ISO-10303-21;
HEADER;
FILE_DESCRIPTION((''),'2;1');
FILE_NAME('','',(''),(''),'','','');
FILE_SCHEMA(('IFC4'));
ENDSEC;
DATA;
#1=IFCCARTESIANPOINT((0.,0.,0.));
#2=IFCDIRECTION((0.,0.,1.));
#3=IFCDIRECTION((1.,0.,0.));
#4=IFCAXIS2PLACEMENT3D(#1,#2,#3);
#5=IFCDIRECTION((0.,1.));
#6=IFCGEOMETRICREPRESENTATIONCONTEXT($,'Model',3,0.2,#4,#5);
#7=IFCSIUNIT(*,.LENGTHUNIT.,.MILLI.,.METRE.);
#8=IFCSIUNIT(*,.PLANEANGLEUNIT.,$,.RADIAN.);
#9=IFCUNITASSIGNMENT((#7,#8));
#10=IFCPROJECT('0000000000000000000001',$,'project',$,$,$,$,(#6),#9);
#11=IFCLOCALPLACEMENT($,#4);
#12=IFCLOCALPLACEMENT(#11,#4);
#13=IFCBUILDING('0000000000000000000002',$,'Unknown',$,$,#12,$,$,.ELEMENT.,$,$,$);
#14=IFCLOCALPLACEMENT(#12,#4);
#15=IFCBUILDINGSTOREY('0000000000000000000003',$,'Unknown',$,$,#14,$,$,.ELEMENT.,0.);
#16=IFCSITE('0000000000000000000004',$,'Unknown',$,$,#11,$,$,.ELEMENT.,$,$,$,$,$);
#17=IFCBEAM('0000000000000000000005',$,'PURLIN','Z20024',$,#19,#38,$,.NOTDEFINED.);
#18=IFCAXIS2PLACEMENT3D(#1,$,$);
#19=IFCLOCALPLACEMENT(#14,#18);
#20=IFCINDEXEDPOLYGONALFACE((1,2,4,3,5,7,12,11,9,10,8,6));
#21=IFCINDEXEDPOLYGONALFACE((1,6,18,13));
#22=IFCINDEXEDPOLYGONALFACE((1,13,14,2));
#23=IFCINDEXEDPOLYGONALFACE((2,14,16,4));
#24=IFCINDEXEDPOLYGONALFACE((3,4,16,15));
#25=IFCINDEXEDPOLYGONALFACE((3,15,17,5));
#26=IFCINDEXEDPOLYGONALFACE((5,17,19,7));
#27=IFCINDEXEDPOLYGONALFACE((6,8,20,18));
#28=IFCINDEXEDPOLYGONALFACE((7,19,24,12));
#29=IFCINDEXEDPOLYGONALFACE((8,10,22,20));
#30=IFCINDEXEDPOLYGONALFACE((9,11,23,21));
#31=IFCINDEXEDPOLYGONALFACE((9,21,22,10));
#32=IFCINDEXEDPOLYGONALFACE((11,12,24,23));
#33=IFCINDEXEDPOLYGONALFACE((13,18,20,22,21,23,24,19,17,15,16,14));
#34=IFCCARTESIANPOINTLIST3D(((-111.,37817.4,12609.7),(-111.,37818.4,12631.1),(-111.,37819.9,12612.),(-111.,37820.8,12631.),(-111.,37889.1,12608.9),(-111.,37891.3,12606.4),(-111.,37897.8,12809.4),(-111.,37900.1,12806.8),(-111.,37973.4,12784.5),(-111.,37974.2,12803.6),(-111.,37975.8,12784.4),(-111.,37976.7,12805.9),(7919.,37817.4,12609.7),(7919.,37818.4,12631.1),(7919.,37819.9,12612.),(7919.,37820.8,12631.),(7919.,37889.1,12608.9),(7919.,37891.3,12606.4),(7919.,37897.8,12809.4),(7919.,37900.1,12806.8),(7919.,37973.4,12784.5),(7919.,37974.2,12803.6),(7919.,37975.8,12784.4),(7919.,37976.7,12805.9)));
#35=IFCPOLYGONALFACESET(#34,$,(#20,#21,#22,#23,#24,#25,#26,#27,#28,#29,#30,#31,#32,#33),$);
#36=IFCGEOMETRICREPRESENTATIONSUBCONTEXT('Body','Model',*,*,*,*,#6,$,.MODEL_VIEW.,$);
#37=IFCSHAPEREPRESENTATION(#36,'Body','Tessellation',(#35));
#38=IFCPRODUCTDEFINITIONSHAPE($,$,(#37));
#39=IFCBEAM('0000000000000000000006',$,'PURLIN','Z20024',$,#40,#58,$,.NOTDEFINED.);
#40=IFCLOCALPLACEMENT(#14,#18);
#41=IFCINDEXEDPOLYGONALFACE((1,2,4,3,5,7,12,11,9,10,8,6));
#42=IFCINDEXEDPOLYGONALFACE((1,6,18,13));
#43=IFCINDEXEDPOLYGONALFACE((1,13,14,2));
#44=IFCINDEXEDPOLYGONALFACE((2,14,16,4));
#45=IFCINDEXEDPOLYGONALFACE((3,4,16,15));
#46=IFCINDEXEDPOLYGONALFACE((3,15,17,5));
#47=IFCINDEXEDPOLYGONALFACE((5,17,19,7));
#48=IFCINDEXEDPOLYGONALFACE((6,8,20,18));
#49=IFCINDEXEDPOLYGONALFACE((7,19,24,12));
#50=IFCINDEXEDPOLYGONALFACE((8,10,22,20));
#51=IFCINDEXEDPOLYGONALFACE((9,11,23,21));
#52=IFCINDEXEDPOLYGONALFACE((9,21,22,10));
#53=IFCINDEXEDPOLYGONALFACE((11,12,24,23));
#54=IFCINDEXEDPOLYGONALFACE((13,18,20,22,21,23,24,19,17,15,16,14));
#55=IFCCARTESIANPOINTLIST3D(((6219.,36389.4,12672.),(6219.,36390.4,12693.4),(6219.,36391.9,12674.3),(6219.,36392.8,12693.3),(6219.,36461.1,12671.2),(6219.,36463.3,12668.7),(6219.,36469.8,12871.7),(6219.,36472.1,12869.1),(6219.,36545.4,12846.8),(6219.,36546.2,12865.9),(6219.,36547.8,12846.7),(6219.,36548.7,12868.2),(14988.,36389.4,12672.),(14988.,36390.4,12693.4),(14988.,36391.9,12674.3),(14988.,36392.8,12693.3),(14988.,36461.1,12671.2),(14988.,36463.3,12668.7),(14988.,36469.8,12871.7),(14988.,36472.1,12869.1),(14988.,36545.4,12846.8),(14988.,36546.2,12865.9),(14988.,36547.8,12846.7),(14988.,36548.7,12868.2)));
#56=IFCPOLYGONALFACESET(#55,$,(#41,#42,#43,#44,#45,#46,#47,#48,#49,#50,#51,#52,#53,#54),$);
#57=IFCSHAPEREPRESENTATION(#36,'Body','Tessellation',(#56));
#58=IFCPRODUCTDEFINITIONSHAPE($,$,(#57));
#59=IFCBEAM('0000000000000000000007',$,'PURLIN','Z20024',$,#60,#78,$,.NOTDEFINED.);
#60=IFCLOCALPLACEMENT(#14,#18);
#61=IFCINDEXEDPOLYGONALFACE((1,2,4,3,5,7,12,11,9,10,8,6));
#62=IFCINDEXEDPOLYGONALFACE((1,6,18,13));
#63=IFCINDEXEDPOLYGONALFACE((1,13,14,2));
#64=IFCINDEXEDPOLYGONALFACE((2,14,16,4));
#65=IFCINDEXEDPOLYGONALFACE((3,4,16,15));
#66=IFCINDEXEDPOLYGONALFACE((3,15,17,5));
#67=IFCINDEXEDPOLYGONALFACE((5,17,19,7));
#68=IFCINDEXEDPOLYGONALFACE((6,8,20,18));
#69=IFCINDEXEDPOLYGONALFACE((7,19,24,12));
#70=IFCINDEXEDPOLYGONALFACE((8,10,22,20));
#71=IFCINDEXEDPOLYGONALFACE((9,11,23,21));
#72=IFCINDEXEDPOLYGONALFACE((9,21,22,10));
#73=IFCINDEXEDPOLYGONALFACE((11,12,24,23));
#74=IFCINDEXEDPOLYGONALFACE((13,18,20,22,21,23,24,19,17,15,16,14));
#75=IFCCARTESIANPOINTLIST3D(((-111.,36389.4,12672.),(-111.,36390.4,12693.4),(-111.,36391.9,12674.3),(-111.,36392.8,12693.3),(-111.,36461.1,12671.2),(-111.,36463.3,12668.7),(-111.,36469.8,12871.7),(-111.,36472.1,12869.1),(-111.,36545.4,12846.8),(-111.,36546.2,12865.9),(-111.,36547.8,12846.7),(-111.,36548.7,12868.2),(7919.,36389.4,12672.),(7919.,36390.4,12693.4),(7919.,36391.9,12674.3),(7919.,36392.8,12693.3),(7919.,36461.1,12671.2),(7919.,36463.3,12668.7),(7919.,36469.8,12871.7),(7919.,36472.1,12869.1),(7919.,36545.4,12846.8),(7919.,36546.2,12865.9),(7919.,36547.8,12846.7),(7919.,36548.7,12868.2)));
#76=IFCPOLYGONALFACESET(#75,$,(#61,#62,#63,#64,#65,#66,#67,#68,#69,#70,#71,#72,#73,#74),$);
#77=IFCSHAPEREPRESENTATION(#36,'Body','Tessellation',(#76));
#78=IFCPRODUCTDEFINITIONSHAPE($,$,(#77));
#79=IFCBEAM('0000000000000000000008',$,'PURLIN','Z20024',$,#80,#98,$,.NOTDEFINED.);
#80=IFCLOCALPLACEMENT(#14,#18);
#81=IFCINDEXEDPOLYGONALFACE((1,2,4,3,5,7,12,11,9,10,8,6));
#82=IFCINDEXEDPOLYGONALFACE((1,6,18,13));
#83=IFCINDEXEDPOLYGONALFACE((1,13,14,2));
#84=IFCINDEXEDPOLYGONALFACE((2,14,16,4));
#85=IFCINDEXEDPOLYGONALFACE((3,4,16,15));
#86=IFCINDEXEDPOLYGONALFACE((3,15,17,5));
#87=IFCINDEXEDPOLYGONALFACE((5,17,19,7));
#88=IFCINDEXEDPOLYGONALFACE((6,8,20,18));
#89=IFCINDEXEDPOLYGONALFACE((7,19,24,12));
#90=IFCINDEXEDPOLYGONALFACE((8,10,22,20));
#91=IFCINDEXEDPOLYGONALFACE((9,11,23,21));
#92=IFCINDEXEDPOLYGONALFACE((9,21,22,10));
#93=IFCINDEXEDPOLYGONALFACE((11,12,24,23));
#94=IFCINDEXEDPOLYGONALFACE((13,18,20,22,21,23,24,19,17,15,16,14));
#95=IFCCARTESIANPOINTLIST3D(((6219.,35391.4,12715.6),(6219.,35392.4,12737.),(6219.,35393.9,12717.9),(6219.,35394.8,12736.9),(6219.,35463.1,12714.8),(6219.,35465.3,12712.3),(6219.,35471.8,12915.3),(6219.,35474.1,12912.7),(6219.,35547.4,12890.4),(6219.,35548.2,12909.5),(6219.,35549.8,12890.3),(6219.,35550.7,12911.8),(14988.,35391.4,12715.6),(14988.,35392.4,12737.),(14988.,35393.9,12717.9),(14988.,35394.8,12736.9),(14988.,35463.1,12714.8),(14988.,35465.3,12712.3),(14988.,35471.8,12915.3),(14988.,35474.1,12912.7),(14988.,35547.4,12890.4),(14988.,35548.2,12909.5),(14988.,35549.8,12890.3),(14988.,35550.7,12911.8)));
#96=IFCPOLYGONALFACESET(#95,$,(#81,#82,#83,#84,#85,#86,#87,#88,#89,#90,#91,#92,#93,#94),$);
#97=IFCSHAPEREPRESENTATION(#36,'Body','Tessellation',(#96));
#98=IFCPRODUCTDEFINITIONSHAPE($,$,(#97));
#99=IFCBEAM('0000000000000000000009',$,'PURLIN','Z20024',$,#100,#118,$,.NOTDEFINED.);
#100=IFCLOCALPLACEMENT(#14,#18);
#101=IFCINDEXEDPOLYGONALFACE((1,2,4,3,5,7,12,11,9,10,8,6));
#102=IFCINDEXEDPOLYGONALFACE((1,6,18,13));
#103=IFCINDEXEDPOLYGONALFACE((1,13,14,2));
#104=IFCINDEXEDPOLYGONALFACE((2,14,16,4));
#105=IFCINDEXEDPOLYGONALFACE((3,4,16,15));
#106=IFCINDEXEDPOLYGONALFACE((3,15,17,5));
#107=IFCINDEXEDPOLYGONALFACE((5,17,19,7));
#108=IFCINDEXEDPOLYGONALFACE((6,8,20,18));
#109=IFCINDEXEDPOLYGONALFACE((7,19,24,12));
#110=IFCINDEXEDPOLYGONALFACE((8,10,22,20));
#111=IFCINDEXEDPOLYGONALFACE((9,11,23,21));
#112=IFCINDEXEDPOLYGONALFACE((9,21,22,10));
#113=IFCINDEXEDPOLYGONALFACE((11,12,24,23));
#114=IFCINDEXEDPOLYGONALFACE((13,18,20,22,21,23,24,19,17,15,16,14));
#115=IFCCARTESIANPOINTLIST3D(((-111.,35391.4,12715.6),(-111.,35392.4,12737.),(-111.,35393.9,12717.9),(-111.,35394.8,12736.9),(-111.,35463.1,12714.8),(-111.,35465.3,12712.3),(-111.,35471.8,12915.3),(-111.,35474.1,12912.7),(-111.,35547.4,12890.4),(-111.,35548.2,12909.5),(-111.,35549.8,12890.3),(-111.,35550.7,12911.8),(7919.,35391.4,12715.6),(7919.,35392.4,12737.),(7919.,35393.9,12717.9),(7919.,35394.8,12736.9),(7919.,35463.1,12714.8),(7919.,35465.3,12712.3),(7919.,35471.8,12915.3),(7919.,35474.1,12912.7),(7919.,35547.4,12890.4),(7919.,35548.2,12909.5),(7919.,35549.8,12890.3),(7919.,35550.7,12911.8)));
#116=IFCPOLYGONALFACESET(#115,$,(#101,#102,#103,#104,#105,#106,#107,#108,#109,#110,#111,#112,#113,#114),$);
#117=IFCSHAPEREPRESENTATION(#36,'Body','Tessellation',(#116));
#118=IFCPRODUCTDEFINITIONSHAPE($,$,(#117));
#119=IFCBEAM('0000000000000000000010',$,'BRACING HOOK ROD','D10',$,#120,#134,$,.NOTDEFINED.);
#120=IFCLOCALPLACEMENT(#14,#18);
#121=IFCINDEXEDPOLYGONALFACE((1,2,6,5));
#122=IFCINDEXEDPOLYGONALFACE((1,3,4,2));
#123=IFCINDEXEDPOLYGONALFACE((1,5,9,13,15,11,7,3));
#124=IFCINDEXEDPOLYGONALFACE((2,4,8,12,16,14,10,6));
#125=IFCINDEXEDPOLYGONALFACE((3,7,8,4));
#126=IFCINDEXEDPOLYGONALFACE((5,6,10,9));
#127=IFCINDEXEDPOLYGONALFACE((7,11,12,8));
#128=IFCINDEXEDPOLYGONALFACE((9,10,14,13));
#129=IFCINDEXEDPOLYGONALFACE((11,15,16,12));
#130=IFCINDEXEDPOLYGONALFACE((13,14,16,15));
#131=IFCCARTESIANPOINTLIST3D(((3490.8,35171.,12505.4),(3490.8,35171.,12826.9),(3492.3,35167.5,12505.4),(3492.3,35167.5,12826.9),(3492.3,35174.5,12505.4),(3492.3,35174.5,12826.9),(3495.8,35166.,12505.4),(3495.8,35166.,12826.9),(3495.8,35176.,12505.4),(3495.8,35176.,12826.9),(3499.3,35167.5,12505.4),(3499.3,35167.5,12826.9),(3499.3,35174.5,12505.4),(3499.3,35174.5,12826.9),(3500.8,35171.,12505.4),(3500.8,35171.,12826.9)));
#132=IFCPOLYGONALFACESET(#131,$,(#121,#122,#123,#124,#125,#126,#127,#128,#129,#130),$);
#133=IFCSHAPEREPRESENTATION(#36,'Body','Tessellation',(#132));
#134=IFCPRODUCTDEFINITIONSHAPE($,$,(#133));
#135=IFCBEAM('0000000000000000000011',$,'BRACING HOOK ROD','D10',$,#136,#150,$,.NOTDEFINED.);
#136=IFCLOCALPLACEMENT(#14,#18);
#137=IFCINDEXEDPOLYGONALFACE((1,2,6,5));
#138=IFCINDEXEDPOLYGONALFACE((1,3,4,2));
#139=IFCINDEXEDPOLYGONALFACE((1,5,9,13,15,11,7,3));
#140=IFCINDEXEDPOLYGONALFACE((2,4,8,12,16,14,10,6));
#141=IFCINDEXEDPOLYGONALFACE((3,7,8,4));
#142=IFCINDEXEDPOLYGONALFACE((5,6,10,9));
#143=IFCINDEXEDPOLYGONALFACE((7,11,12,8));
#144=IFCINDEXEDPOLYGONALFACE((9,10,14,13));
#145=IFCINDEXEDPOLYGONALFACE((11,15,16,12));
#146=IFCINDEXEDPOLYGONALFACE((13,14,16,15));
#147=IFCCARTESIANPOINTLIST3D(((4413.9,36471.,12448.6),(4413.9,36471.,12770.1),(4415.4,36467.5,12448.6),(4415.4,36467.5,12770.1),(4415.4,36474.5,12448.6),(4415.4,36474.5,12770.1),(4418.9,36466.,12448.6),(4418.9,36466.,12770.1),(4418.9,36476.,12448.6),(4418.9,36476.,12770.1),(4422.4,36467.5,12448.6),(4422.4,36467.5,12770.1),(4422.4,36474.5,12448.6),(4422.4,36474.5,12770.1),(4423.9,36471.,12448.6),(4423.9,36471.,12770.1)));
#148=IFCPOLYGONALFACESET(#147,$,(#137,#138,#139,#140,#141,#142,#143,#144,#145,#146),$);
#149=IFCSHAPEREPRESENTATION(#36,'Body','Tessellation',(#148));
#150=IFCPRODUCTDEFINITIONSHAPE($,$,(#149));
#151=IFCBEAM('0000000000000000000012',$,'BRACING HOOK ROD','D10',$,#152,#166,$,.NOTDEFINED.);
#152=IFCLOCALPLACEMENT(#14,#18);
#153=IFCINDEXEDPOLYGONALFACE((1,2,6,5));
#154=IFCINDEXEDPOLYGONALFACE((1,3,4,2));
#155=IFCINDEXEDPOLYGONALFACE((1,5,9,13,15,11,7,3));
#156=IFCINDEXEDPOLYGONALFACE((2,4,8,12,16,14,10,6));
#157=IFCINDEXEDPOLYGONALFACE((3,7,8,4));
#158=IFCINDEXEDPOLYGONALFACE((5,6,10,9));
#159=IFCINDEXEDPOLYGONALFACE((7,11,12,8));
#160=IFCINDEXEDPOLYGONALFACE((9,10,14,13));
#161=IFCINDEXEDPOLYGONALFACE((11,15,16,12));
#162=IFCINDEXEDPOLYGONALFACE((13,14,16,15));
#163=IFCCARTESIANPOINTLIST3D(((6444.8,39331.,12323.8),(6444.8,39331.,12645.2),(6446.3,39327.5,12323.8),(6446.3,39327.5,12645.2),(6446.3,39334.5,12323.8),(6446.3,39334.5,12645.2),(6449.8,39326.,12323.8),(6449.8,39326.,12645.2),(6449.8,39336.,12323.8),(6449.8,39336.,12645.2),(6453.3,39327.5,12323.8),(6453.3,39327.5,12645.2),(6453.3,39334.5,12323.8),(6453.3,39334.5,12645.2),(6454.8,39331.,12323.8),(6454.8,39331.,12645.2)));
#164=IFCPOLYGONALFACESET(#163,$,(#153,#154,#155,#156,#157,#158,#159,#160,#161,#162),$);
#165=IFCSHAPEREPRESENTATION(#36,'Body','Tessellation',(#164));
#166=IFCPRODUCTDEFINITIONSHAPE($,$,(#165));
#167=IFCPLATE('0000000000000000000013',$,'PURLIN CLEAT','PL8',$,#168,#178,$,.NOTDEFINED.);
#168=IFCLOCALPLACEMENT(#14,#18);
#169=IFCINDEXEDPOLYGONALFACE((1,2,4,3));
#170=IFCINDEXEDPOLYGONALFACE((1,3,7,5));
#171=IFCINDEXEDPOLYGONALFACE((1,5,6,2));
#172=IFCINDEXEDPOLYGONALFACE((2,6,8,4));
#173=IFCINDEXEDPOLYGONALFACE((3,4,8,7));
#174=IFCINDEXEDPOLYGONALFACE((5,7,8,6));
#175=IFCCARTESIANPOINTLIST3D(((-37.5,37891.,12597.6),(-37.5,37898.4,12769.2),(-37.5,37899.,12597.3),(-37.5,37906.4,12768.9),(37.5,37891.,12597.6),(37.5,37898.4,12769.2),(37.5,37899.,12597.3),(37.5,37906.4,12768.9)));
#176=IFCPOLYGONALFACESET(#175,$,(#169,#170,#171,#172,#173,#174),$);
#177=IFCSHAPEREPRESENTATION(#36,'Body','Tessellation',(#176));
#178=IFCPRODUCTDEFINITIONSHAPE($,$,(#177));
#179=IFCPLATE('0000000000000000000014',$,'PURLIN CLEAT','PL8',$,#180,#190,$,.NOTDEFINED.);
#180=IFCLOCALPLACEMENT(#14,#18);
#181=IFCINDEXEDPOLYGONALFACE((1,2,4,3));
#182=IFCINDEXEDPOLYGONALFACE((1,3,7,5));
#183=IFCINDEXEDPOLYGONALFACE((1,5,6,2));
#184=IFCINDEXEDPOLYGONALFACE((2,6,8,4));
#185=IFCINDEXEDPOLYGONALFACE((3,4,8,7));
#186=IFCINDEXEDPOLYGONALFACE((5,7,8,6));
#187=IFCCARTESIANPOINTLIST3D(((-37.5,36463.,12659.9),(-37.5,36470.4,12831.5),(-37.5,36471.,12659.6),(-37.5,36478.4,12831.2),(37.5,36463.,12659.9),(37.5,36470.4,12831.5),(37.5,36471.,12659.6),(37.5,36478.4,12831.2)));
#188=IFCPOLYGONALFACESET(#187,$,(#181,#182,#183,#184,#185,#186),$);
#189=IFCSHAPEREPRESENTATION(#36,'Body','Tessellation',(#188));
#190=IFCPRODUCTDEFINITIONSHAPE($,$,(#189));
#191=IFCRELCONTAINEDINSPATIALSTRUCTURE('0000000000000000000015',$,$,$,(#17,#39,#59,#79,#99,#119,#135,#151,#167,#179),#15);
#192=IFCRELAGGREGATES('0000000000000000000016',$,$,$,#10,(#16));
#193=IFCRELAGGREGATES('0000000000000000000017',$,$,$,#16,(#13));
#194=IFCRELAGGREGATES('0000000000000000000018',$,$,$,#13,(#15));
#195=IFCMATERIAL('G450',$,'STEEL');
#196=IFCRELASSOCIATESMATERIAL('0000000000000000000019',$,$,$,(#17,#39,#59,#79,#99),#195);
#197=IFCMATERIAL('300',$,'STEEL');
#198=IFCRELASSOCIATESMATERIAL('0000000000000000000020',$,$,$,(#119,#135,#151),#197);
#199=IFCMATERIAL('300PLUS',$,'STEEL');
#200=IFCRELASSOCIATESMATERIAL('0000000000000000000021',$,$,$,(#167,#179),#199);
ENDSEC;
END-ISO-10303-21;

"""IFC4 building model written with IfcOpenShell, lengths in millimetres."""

from ifc_helpers import new_model, si_unit, direction, frame, origin_with_axes, place, context, subcontext, project, spatial, line, indexed_curve, outline, extrude, material, element, save


model = new_model("IFC4")

# Units and contexts
model_context = context("Model", 3, precision=0.2, world=origin_with_axes(), true_north=direction((0.0, 1.0)))
body_context = subcontext(model_context, "Body", "Model", "MODEL_VIEW")
ifc_project = project(units=[si_unit("LENGTHUNIT", "METRE", prefix="MILLI"), si_unit("PLANEANGLEUNIT", "RADIAN")], contexts=[model_context])

# Site, building, storey
site_placement = place(None, origin_with_axes())
site = spatial("IfcSite", under=ifc_project, at=site_placement, Name="Unknown", CompositionType="ELEMENT")
building_placement = place(site_placement, origin_with_axes())
building = spatial("IfcBuilding", under=site, at=building_placement, Name="Unknown", CompositionType="ELEMENT")
storey_placement = place(building_placement, origin_with_axes())
storey = spatial("IfcBuildingStorey", under=building, at=storey_placement, Name="Unknown", CompositionType="ELEMENT", Elevation=0.0)

# Beams
ifc_material_1 = material(Name="G450", Category="STEEL")
beam_1_placement = place(storey_placement, frame((-111.0, 37894.6, 12707.9), z_axis=(0.0, -0.999048, 0.043619), x_axis=(1.0, 0.0, 0.0)))
element("IfcBeam", 1, at=beam_1_placement, inside=storey, material=ifc_material_1, Name="PURLIN", Description="Z20024", PredefinedType="NOTDEFINED", context=body_context, shape_type="SolidModel", body=[
    extrude(outline(indexed_curve([(72.8, -101.5), (72.8, -80.0), (70.4, -80.0), (70.4, -99.1), (1.2, -99.1), (1.2, 101.5), (-77.8, 101.5), (-77.8, 80.0), (-75.4, 80.0), (-75.4, 99.1), (-1.2, 99.1), (-1.2, -101.5)], segments=[line(1, 2, 3, 4, 5, 6, 7, 8, 9, 10, 11, 12, 1)])), frame((0.0, 0.0, 0.0), z_axis=(-1.0, 0.0, 0.0), x_axis=(0.0, 0.0, 1.0)), (0.0, 0.0, -1.0), 8030.0),
])
beam_2_placement = place(storey_placement, frame((6219.0, 36466.6, 12770.2), z_axis=(0.0, -0.999048, 0.043619), x_axis=(1.0, 0.0, 0.0)))
element("IfcBeam", 2, at=beam_2_placement, inside=storey, material=ifc_material_1, Name="PURLIN", Description="Z20024", PredefinedType="NOTDEFINED", context=body_context, shape_type="SolidModel", body=[
    extrude(outline(indexed_curve([(72.8, -101.5), (72.8, -80.0), (70.4, -80.0), (70.4, -99.1), (1.2, -99.1), (1.2, 101.5), (-77.8, 101.5), (-77.8, 80.0), (-75.4, 80.0), (-75.4, 99.1), (-1.2, 99.1), (-1.2, -101.5)], segments=[line(1, 2, 3, 4, 5, 6, 7, 8, 9, 10, 11, 12, 1)])), frame((0.0, 0.0, 0.0), z_axis=(-1.0, 0.0, 0.0), x_axis=(0.0, 0.0, 1.0)), (0.0, 0.0, -1.0), 8769.0),
])
beam_3_placement = place(storey_placement, frame((-111.0, 36466.6, 12770.2), z_axis=(0.0, -0.999048, 0.043619), x_axis=(1.0, 0.0, 0.0)))
element("IfcBeam", 3, at=beam_3_placement, inside=storey, material=ifc_material_1, Name="PURLIN", Description="Z20024", PredefinedType="NOTDEFINED", context=body_context, shape_type="SolidModel", body=[
    extrude(outline(indexed_curve([(72.8, -101.5), (72.8, -80.0), (70.4, -80.0), (70.4, -99.1), (1.2, -99.1), (1.2, 101.5), (-77.8, 101.5), (-77.8, 80.0), (-75.4, 80.0), (-75.4, 99.1), (-1.2, 99.1), (-1.2, -101.5)], segments=[line(1, 2, 3, 4, 5, 6, 7, 8, 9, 10, 11, 12, 1)])), frame((0.0, 0.0, 0.0), z_axis=(-1.0, 0.0, 0.0), x_axis=(0.0, 0.0, 1.0)), (0.0, 0.0, -1.0), 8030.0),
])
beam_4_placement = place(storey_placement, frame((6219.0, 35468.6, 12813.8), z_axis=(0.0, -0.999048, 0.043619), x_axis=(1.0, 0.0, 0.0)))
element("IfcBeam", 4, at=beam_4_placement, inside=storey, material=ifc_material_1, Name="PURLIN", Description="Z20024", PredefinedType="NOTDEFINED", context=body_context, shape_type="SolidModel", body=[
    extrude(outline(indexed_curve([(72.8, -101.5), (72.8, -80.0), (70.4, -80.0), (70.4, -99.1), (1.2, -99.1), (1.2, 101.5), (-77.8, 101.5), (-77.8, 80.0), (-75.4, 80.0), (-75.4, 99.1), (-1.2, 99.1), (-1.2, -101.5)], segments=[line(1, 2, 3, 4, 5, 6, 7, 8, 9, 10, 11, 12, 1)])), frame((0.0, 0.0, 0.0), z_axis=(-1.0, 0.0, 0.0), x_axis=(0.0, 0.0, 1.0)), (0.0, 0.0, -1.0), 8769.0),
])
beam_5_placement = place(storey_placement, frame((-111.0, 35468.6, 12813.8), z_axis=(0.0, -0.999048, 0.043619), x_axis=(1.0, 0.0, 0.0)))
element("IfcBeam", 5, at=beam_5_placement, inside=storey, material=ifc_material_1, Name="PURLIN", Description="Z20024", PredefinedType="NOTDEFINED", context=body_context, shape_type="SolidModel", body=[
    extrude(outline(indexed_curve([(72.8, -101.5), (72.8, -80.0), (70.4, -80.0), (70.4, -99.1), (1.2, -99.1), (1.2, 101.5), (-77.8, 101.5), (-77.8, 80.0), (-75.4, 80.0), (-75.4, 99.1), (-1.2, 99.1), (-1.2, -101.5)], segments=[line(1, 2, 3, 4, 5, 6, 7, 8, 9, 10, 11, 12, 1)])), frame((0.0, 0.0, 0.0), z_axis=(-1.0, 0.0, 0.0), x_axis=(0.0, 0.0, 1.0)), (0.0, 0.0, -1.0), 8030.0),
])
ifc_material_2 = material(Name="300", Category="STEEL")
for number, where, z_axis, x_axis, name in (
    (6, (3495.8, 35171.0, 12826.9), (1.0, 0.0, 0.0), (0.0, 0.0, -1.0), "BRACING HOOK ROD"),
    (7, (4418.9, 36471.0, 12770.1), (1.0, 0.0, 0.0), (0.0, 0.0, -1.0), "BRACING HOOK ROD"),
):
    element("IfcBeam", number, at=place(storey_placement, frame(where, z_axis=z_axis, x_axis=x_axis)), inside=storey, material=ifc_material_2, Name=name, Description="D10", PredefinedType="NOTDEFINED", context=body_context, shape_type="SolidModel", body=[
        extrude(outline(indexed_curve([(5.0, 0.0), (3.5, 3.5), (0.0, 5.0), (-3.5, 3.5), (-5.0, 0.0), (-3.5, -3.5), (0.0, -5.0), (3.5, -3.5)], segments=[line(1, 2, 3, 4, 5, 6, 7, 8, 1)])), frame((0.0, 0.0, 0.0), z_axis=(-1.0, 0.0, 0.0), x_axis=(0.0, 0.0, 1.0)), (0.0, 0.0, -1.0), 321.5),
    ])
beam_6_placement = place(storey_placement, frame((6449.8, 39331.0, 12645.2), z_axis=(1.0, 0.0, 0.0), x_axis=(0.0, 0.0, -1.0)))
element("IfcBeam", 8, at=beam_6_placement, inside=storey, material=ifc_material_2, Name="BRACING HOOK ROD", Description="D10", PredefinedType="NOTDEFINED", context=body_context, shape_type="SolidModel", body=[
    extrude(outline(indexed_curve([(5.0, 0.0), (3.5, 3.5), (0.0, 5.0), (-3.5, 3.5), (-5.0, 0.0), (-3.5, -3.5), (0.0, -5.0), (3.5, -3.5)], segments=[line(1, 2, 3, 4, 5, 6, 7, 8, 1)])), frame((0.0, 0.0, 0.0), z_axis=(-1.0, 0.0, 0.0), x_axis=(0.0, 0.0, 1.0)), (0.0, 0.0, -1.0), 321.4),
])

# Plates
ifc_material_3 = material(Name="300PLUS", Category="STEEL")
for number, where, z_axis, x_axis, name in (
    (9, (-37.5, 37895.0, 12597.5), (0.0, -0.999071, 0.043084), (1.0, 0.0, 0.0), "PURLIN CLEAT"),
    (10, (-37.5, 36467.0, 12659.8), (0.0, -0.999071, 0.043084), (1.0, 0.0, 0.0), "PURLIN CLEAT"),
):
    element("IfcPlate", number, at=place(storey_placement, frame(where, z_axis=z_axis, x_axis=x_axis)), inside=storey, material=ifc_material_3, Name=name, Description="PL8", PredefinedType="NOTDEFINED", context=body_context, shape_type="SolidModel", body=[
        extrude(outline(indexed_curve([(0.0, 0.0), (75.0, 0.0), (75.0, 171.8), (0.0, 171.8)], segments=[line(1, 2, 3, 4, 1)])), frame((0.0, 0.0, 4.0), z_axis=(0.0, 0.0, 1.0), x_axis=(1.0, 0.0, 0.0)), (0.0, 0.0, -1.0), 8.0),
    ])

save(model, "model.ifc")
